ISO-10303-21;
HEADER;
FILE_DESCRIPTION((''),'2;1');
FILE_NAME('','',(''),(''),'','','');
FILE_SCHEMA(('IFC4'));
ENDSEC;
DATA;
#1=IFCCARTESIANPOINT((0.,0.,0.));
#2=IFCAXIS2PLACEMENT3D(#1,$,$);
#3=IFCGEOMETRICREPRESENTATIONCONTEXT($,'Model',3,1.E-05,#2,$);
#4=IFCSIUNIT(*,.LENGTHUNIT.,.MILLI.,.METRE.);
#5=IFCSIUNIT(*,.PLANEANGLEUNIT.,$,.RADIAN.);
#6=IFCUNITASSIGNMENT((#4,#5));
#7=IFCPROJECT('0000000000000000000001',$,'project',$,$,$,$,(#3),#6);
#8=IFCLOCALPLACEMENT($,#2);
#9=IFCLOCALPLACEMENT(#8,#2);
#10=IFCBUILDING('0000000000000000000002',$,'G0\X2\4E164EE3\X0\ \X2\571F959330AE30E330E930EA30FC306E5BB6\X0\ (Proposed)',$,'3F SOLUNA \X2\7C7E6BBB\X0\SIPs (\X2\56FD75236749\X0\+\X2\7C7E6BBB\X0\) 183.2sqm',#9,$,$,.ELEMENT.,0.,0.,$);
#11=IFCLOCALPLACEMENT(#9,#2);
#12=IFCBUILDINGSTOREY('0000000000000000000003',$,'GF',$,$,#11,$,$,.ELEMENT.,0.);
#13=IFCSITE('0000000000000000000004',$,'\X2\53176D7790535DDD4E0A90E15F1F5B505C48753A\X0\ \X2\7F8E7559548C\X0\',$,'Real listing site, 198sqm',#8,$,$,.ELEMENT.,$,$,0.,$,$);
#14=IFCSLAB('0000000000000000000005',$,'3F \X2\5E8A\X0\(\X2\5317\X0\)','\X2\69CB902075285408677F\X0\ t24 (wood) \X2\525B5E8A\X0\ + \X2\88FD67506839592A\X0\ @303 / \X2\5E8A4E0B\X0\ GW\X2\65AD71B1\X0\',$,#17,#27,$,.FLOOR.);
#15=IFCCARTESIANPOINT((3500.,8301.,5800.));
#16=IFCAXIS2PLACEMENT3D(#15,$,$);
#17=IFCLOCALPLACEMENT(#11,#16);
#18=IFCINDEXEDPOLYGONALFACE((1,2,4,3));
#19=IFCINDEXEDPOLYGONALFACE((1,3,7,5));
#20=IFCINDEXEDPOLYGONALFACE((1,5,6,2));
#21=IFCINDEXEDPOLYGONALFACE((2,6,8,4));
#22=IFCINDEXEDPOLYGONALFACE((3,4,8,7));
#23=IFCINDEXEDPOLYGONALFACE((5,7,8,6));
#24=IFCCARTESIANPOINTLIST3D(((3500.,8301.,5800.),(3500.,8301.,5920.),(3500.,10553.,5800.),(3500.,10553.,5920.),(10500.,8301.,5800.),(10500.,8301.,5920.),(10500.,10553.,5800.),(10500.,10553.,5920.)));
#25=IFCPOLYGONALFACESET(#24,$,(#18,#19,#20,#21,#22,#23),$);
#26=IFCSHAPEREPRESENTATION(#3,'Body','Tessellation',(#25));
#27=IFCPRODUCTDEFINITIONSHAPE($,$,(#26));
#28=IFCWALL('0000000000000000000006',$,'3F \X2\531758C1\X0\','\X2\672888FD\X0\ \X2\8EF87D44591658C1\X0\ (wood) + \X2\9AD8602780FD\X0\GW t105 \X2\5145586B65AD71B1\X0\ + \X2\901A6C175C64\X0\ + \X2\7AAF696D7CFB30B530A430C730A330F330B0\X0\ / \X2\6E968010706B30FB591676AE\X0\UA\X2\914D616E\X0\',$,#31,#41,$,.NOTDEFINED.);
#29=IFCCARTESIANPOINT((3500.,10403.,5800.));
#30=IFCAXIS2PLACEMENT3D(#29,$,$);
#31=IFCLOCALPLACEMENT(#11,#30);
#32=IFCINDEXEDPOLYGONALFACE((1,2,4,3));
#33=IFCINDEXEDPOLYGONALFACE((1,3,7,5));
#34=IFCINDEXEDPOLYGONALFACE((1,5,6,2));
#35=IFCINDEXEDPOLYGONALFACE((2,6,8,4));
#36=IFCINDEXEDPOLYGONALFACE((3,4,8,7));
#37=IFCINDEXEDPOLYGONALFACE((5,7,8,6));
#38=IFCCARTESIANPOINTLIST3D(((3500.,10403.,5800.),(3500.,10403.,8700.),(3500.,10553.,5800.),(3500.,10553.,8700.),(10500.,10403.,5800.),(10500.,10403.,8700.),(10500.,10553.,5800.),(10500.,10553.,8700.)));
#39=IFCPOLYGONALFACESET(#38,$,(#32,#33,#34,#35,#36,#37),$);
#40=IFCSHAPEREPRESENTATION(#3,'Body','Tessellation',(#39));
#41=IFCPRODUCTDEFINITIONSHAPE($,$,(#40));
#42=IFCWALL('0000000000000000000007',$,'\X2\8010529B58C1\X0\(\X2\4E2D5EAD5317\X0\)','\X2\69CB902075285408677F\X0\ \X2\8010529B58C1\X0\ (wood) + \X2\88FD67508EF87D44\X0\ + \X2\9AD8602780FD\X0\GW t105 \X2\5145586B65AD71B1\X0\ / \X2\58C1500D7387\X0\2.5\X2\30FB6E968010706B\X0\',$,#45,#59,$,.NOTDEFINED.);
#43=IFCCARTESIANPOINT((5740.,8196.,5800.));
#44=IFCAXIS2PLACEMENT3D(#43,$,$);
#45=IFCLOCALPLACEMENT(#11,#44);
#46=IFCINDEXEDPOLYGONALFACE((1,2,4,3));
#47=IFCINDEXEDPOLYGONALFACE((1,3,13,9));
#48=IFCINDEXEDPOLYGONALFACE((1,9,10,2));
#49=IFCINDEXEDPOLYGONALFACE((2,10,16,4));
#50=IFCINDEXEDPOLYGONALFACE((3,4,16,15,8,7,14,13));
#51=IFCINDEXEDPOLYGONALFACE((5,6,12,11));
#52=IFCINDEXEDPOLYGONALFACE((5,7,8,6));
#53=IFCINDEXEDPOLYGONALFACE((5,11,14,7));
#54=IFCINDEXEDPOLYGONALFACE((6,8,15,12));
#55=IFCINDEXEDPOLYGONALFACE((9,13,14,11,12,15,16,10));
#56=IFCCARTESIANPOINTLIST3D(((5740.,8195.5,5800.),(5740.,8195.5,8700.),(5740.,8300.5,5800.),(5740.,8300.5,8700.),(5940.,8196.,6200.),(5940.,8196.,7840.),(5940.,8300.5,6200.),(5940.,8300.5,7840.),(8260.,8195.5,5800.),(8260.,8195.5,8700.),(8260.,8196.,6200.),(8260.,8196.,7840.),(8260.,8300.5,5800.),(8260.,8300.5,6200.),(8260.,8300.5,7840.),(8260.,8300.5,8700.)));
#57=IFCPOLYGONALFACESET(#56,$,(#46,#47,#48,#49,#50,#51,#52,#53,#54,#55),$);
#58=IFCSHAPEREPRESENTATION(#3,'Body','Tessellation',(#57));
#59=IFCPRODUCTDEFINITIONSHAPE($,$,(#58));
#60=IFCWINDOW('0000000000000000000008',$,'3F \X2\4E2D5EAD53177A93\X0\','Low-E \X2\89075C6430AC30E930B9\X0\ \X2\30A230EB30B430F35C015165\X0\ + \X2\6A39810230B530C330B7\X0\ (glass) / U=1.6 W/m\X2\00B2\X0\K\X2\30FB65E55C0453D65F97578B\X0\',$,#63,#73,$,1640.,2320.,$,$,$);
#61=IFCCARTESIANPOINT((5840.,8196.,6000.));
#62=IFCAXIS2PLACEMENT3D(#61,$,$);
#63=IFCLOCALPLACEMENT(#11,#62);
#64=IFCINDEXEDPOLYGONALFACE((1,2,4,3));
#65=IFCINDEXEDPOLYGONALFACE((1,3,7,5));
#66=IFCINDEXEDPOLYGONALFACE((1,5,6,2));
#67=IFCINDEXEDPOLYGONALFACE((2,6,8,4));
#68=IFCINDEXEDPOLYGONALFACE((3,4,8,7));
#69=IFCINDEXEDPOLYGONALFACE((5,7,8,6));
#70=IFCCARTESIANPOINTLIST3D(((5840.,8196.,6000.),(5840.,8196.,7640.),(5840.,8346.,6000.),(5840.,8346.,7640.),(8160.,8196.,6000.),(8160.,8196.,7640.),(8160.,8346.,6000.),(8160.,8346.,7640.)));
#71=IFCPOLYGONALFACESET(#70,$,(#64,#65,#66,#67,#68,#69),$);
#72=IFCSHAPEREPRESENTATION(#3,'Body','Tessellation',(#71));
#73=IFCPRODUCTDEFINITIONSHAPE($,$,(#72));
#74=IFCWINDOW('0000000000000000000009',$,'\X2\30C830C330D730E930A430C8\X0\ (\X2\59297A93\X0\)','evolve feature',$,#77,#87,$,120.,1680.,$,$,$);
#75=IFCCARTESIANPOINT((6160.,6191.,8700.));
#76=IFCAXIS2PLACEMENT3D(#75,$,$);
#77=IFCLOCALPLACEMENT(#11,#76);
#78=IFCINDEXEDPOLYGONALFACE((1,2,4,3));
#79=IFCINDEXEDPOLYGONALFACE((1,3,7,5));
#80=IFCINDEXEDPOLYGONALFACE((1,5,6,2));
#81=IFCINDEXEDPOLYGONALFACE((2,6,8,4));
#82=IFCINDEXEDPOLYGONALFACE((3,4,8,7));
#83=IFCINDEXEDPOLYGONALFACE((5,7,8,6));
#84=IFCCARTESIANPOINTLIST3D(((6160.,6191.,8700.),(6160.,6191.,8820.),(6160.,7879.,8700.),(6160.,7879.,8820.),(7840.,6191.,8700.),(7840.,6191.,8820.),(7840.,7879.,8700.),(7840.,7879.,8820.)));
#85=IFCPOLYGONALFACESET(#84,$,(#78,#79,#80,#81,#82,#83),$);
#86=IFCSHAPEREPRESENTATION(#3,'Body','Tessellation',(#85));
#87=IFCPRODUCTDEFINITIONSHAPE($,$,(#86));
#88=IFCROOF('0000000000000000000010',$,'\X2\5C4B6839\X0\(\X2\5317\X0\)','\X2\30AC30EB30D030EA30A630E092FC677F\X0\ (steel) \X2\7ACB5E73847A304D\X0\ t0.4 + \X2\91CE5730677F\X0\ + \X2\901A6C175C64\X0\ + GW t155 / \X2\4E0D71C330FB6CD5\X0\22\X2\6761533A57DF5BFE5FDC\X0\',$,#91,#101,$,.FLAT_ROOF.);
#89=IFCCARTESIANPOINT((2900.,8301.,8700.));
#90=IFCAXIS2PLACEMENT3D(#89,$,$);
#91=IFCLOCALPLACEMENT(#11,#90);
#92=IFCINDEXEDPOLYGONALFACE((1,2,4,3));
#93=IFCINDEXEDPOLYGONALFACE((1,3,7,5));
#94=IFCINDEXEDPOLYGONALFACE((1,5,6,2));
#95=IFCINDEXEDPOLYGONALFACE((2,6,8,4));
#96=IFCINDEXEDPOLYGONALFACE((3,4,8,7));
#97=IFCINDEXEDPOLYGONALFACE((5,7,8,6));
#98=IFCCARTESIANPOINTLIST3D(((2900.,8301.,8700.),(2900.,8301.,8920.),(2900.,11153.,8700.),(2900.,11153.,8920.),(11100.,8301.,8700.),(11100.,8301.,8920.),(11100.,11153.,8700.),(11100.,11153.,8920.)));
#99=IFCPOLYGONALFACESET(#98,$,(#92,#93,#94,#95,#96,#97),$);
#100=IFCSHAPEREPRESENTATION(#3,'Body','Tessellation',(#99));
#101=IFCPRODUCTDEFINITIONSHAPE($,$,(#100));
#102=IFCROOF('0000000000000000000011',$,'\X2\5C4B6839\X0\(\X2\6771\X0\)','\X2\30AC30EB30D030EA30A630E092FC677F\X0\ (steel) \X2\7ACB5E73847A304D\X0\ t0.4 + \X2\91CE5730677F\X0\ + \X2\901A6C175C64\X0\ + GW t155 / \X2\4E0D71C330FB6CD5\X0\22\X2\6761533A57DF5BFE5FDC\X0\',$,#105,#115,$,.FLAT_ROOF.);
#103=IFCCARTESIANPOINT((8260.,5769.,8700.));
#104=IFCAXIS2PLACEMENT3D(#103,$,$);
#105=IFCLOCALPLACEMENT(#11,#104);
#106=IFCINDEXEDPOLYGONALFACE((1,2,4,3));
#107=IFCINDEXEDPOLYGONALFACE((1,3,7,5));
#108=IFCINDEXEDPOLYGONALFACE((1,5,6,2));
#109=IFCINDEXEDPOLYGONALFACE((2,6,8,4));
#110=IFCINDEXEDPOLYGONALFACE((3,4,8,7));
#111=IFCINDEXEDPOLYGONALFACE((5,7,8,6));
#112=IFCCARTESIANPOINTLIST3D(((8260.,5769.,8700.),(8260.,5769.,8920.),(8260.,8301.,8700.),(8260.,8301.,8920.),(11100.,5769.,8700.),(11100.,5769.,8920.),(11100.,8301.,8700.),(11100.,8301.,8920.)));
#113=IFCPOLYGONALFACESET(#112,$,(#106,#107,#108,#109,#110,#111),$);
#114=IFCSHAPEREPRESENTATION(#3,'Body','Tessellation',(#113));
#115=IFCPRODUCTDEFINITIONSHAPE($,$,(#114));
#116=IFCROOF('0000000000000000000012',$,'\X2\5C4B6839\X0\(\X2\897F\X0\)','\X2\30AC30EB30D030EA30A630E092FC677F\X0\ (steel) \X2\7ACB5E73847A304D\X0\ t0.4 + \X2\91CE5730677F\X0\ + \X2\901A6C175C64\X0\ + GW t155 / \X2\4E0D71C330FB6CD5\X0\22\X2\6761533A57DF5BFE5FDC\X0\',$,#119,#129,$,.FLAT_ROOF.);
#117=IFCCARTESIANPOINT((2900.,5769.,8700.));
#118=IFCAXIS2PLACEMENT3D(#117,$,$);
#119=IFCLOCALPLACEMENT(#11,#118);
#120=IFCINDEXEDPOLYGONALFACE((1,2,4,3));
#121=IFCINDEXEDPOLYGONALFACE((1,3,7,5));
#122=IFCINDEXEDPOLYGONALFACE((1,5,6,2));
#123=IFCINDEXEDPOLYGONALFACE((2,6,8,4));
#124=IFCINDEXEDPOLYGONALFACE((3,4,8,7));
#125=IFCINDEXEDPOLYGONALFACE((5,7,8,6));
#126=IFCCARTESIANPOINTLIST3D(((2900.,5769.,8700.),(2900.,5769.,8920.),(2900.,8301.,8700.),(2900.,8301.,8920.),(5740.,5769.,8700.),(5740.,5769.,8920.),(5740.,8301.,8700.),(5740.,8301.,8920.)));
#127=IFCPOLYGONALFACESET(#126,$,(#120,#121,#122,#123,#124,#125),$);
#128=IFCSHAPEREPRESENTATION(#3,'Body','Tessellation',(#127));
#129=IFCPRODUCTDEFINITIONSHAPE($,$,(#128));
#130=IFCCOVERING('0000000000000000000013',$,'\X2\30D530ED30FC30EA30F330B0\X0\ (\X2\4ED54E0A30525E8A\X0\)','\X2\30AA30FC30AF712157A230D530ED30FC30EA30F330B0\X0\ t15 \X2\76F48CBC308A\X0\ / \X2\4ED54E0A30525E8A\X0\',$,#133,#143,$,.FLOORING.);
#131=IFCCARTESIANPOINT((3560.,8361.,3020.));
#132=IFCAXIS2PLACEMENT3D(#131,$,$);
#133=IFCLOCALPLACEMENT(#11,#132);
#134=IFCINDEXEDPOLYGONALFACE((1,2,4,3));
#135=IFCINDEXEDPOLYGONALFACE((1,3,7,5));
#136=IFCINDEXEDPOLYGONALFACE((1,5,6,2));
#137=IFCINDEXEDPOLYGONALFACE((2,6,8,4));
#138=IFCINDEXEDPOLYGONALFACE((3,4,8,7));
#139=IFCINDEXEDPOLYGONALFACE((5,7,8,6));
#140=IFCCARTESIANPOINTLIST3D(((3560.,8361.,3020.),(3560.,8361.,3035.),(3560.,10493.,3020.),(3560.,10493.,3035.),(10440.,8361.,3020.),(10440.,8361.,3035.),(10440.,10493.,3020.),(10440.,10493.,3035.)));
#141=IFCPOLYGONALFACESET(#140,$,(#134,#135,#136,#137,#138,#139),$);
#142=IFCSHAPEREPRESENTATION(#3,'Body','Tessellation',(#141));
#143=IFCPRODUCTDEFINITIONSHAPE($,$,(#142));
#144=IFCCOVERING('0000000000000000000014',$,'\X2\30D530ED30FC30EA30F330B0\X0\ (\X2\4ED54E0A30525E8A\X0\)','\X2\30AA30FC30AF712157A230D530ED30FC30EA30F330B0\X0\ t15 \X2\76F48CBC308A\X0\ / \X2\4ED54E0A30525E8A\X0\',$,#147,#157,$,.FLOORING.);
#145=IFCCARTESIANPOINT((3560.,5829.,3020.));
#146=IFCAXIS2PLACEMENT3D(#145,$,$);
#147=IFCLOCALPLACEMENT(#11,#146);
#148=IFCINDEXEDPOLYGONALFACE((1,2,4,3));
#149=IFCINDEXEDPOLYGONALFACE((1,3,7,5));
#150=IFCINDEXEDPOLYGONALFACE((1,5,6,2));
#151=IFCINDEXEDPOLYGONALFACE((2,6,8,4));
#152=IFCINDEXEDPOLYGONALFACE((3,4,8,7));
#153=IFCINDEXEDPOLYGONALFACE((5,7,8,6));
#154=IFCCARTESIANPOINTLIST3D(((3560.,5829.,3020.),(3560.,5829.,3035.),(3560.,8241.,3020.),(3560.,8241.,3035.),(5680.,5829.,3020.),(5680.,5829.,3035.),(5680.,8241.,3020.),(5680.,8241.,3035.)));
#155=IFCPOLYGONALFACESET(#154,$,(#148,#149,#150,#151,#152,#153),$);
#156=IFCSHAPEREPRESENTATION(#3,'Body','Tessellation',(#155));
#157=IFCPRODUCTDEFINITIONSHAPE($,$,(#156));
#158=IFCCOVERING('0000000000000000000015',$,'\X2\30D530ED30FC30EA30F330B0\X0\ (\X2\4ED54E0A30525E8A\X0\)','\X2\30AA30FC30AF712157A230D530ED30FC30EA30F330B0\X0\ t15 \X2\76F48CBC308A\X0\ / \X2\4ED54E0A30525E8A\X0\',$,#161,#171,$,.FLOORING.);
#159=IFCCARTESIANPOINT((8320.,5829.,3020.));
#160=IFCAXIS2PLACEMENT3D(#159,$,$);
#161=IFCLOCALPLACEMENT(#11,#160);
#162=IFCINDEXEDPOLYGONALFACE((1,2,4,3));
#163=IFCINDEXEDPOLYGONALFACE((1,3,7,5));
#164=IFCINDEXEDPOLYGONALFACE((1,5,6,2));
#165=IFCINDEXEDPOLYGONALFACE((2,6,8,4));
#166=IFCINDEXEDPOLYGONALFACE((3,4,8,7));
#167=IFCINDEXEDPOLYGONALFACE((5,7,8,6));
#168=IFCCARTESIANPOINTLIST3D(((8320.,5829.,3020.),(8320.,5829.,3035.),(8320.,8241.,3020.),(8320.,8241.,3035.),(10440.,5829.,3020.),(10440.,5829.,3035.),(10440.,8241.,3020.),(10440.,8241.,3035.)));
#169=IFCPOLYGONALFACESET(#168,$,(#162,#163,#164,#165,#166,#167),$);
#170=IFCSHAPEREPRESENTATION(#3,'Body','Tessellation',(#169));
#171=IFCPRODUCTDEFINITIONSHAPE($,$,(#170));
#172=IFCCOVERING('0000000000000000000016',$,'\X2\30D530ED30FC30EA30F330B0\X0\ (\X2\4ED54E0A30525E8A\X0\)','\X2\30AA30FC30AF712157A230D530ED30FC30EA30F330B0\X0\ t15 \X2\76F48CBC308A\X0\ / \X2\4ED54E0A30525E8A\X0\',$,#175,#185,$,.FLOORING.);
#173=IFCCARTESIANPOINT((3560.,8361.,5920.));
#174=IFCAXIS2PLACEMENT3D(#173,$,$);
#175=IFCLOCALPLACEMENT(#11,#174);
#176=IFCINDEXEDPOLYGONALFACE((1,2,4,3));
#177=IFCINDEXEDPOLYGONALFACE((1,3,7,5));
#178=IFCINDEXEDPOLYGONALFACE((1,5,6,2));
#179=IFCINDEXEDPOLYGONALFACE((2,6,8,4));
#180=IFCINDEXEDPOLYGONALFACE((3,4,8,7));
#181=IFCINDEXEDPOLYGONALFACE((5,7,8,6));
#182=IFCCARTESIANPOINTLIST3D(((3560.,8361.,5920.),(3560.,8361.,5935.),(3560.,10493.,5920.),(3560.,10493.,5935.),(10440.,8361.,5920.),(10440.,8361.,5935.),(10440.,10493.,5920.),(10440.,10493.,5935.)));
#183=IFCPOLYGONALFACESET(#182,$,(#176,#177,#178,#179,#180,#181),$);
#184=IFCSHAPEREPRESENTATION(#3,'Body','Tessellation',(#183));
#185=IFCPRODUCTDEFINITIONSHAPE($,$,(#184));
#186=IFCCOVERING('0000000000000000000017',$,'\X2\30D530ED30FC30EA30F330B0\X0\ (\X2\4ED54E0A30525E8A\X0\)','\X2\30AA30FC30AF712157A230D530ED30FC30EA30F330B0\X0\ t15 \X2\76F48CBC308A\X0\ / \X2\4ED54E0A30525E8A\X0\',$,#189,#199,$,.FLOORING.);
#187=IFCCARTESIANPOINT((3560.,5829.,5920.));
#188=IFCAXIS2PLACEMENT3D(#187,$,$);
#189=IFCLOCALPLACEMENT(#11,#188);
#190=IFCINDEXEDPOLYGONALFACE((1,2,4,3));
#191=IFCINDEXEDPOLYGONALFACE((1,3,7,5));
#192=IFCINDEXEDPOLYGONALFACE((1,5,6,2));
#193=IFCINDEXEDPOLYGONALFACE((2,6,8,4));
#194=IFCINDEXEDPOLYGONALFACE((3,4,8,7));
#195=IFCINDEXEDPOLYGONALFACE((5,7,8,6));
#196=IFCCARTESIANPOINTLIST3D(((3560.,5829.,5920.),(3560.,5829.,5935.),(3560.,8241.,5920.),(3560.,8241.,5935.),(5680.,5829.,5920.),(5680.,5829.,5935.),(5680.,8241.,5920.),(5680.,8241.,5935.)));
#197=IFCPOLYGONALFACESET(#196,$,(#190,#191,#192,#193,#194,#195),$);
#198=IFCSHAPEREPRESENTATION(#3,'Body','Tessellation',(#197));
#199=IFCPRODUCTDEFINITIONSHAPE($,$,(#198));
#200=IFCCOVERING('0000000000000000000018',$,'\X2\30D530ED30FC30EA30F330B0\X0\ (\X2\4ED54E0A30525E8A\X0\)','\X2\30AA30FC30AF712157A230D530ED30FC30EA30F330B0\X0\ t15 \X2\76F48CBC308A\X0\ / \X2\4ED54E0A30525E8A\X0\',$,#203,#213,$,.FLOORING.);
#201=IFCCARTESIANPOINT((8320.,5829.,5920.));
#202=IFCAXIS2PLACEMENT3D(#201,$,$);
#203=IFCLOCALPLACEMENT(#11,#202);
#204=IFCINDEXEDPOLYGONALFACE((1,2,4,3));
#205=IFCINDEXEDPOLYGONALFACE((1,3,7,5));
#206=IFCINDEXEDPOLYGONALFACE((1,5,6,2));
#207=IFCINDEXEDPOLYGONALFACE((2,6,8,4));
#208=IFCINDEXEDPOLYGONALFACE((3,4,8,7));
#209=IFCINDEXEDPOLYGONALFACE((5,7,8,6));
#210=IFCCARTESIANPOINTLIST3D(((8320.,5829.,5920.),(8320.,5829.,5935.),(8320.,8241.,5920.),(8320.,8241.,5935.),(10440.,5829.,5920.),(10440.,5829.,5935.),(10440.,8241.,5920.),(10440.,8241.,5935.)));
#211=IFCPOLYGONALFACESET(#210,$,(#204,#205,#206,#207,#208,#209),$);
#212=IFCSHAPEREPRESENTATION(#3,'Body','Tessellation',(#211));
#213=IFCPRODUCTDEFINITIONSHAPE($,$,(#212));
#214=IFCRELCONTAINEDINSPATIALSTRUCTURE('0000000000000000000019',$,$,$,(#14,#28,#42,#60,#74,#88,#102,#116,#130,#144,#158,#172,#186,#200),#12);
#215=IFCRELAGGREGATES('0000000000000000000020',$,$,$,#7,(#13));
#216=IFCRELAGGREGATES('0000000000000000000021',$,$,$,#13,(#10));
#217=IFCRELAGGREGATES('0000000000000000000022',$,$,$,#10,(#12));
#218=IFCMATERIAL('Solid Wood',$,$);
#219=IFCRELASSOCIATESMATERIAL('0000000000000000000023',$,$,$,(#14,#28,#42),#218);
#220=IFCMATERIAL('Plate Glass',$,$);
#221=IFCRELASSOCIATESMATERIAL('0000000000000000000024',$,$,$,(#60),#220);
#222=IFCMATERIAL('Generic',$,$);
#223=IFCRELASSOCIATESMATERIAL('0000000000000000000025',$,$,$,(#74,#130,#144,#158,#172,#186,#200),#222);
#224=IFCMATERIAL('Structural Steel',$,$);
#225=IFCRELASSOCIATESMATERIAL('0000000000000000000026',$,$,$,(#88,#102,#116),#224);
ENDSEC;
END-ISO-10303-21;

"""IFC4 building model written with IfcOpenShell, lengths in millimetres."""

from ifc_helpers import new_model, si_unit, frame, frame_2d, origin, place, context, project, spatial, rectangle, extrude, material, element, fill, save


model = new_model("IFC4")

# Units and contexts
model_context = context("Model", 3, precision=1e-05, world=origin())
ifc_project = project(units=[si_unit("LENGTHUNIT", "METRE", prefix="MILLI"), si_unit("PLANEANGLEUNIT", "RADIAN")], contexts=[model_context])

# Site, building, storey
site_placement = place(None, origin())
site = spatial("IfcSite", under=ifc_project, at=site_placement, Name="北海道川上郡弟子屈町 美留和", ObjectType="Real listing site, 198sqm", CompositionType="ELEMENT", RefElevation=0.0)
building_placement = place(site_placement, origin())
building = spatial("IfcBuilding", under=site, at=building_placement, Name="G0世代 土間ギャラリーの家 (Proposed)", ObjectType="3F SOLUNA 籾殻SIPs (国産杉+籾殻) 183.2sqm", CompositionType="ELEMENT", ElevationOfRefHeight=0.0, ElevationOfTerrain=0.0)
storey_placement = place(building_placement, origin())
storey = spatial("IfcBuildingStorey", under=building, at=storey_placement, Name="GF", CompositionType="ELEMENT", Elevation=0.0)

# Slab
ifc_material_1 = material(Name="Solid Wood")
slab_placement = place(storey_placement, frame((3500.0, 8301.0, 5800.0)))
element("IfcSlab", 1, at=slab_placement, inside=storey, material=ifc_material_1, Name="3F 床(北)", Description="構造用合板 t24 (wood) 剛床 + 製材根太 @303 / 床下 GW断熱", PredefinedType="FLOOR", context=model_context, shape_type="SweptSolid", body=[
    extrude(rectangle(XDim=7000.0, YDim=2252.0, at=frame_2d((3500.0, 1126.0))), frame((3500.0, 8301.0, 5800.0)), (0.0, 0.0, 1.0), 120.0),
])

# Wall
wall_1_placement = place(storey_placement, frame((3500.0, 10403.0, 5800.0)))
element("IfcWall", 2, at=wall_1_placement, inside=storey, material=ifc_material_1, Name="3F 北壁", Description="木製 軸組外壁 (wood) + 高性能GW t105 充填断熱 + 通気層 + 窯業系サイディング / 準耐火・外皮UA配慮", PredefinedType="NOTDEFINED", context=model_context, shape_type="SweptSolid", body=[
    extrude(rectangle(XDim=7000.0, YDim=150.0, at=frame_2d((3500.0, 75.0))), frame((3500.0, 10403.0, 5800.0)), (0.0, 0.0, 1.0), 2900.0),
])

# Wall, opening, window
wall_2_placement = place(storey_placement, frame((5740.0, 8196.0, 5800.0)))
wall_2 = element("IfcWall", 3, at=wall_2_placement, inside=storey, material=ifc_material_1, Name="耐力壁(中庭北)", Description="構造用合板 耐力壁 (wood) + 製材軸組 + 高性能GW t105 充填断熱 / 壁倍率2.5・準耐火", PredefinedType="NOTDEFINED", context=model_context, shape_type="SweptSolid", body=[
    extrude(rectangle(XDim=2520.0, YDim=105.0, at=frame_2d((1260.0, 52.0))), frame((5740.0, 8196.0, 5800.0)), (0.0, 0.0, 1.0), 2900.0),
])
opening_placement = place(storey_placement, frame((5840.0, 8196.0, 6000.0)))
opening = element("IfcOpeningElement", 4, at=opening_placement, cuts=wall_2, PredefinedType="NOTDEFINED", context=model_context, shape_type="SweptSolid", body=[
    extrude(rectangle(XDim=2320.0, YDim=150.0, at=frame_2d((1160.0, 75.0))), frame((5840.0, 8196.0, 6000.0)), (0.0, 0.0, 1.0), 1640.0),
])
ifc_material_2 = material(Name="Plate Glass")
window_1_placement = place(storey_placement, frame((5840.0, 8196.0, 6000.0)))
window_1 = element("IfcWindow", 5, at=window_1_placement, inside=storey, material=ifc_material_2, Name="3F 中庭北窓", Description="Low-E 複層ガラス アルゴン封入 + 樹脂サッシ (glass) / U=1.6 W/m²K・日射取得型", OverallHeight=1640.0, OverallWidth=2320.0, context=model_context, shape_type="SweptSolid", body=[
    extrude(rectangle(XDim=2320.0, YDim=150.0, at=frame_2d((1160.0, 75.0))), frame((5840.0, 8196.0, 6000.0)), (0.0, 0.0, 1.0), 1640.0),
])
fill(opening, window_1)

# Window
ifc_material_3 = material(Name="Generic")
window_2_placement = place(storey_placement, frame((6160.0, 6191.0, 8700.0)))
element("IfcWindow", 6, at=window_2_placement, inside=storey, material=ifc_material_3, Name="トップライト (天窓)", Description="evolve feature", OverallHeight=120.0, OverallWidth=1680.0, context=model_context, shape_type="SweptSolid", body=[
    extrude(rectangle(XDim=1680.0, YDim=1688.0, at=frame_2d((840.0, 844.0))), frame((6160.0, 6191.0, 8700.0)), (0.0, 0.0, 1.0), 120.0),
])

# Roofs
ifc_material_4 = material(Name="Structural Steel")
roof_1_placement = place(storey_placement, frame((2900.0, 8301.0, 8700.0)))
element("IfcRoof", 7, at=roof_1_placement, inside=storey, material=ifc_material_4, Name="屋根(北)", Description="ガルバリウム鋼板 (steel) 立平葺き t0.4 + 野地板 + 通気層 + GW t155 / 不燃・法22条区域対応", PredefinedType="FLAT_ROOF", context=model_context, shape_type="SweptSolid", body=[
    extrude(rectangle(XDim=8200.0, YDim=2852.0, at=frame_2d((4100.0, 1426.0))), frame((2900.0, 8301.0, 8700.0)), (0.0, 0.0, 1.0), 220.0),
])
roof_2_placement = place(storey_placement, frame((8260.0, 5769.0, 8700.0)))
element("IfcRoof", 8, at=roof_2_placement, inside=storey, material=ifc_material_4, Name="屋根(東)", Description="ガルバリウム鋼板 (steel) 立平葺き t0.4 + 野地板 + 通気層 + GW t155 / 不燃・法22条区域対応", PredefinedType="FLAT_ROOF", context=model_context, shape_type="SweptSolid", body=[
    extrude(rectangle(XDim=2840.0, YDim=2532.0, at=frame_2d((1420.0, 1266.0))), frame((8260.0, 5769.0, 8700.0)), (0.0, 0.0, 1.0), 220.0),
])
roof_3_placement = place(storey_placement, frame((2900.0, 5769.0, 8700.0)))
element("IfcRoof", 9, at=roof_3_placement, inside=storey, material=ifc_material_4, Name="屋根(西)", Description="ガルバリウム鋼板 (steel) 立平葺き t0.4 + 野地板 + 通気層 + GW t155 / 不燃・法22条区域対応", PredefinedType="FLAT_ROOF", context=model_context, shape_type="SweptSolid", body=[
    extrude(rectangle(XDim=2840.0, YDim=2532.0, at=frame_2d((1420.0, 1266.0))), frame((2900.0, 5769.0, 8700.0)), (0.0, 0.0, 1.0), 220.0),
])

# Coverings
covering_1_placement = place(storey_placement, frame((3560.0, 8361.0, 3020.0)))
element("IfcCovering", 10, at=covering_1_placement, inside=storey, material=ifc_material_3, Name="フローリング (仕上げ床)", Description="オーク無垢フローリング t15 直貼り / 仕上げ床", PredefinedType="FLOORING", context=model_context, shape_type="SweptSolid", body=[
    extrude(rectangle(XDim=6880.0, YDim=2132.0, at=frame_2d((3440.0, 1066.0))), frame((3560.0, 8361.0, 3020.0)), (0.0, 0.0, 1.0), 15.0),
])
covering_2_placement = place(storey_placement, frame((3560.0, 5829.0, 3020.0)))
element("IfcCovering", 11, at=covering_2_placement, inside=storey, material=ifc_material_3, Name="フローリング (仕上げ床)", Description="オーク無垢フローリング t15 直貼り / 仕上げ床", PredefinedType="FLOORING", context=model_context, shape_type="SweptSolid", body=[
    extrude(rectangle(XDim=2120.0, YDim=2412.0, at=frame_2d((1060.0, 1206.0))), frame((3560.0, 5829.0, 3020.0)), (0.0, 0.0, 1.0), 15.0),
])
covering_3_placement = place(storey_placement, frame((8320.0, 5829.0, 3020.0)))
element("IfcCovering", 12, at=covering_3_placement, inside=storey, material=ifc_material_3, Name="フローリング (仕上げ床)", Description="オーク無垢フローリング t15 直貼り / 仕上げ床", PredefinedType="FLOORING", context=model_context, shape_type="SweptSolid", body=[
    extrude(rectangle(XDim=2120.0, YDim=2412.0, at=frame_2d((1060.0, 1206.0))), frame((8320.0, 5829.0, 3020.0)), (0.0, 0.0, 1.0), 15.0),
])
covering_4_placement = place(storey_placement, frame((3560.0, 8361.0, 5920.0)))
element("IfcCovering", 13, at=covering_4_placement, inside=storey, material=ifc_material_3, Name="フローリング (仕上げ床)", Description="オーク無垢フローリング t15 直貼り / 仕上げ床", PredefinedType="FLOORING", context=model_context, shape_type="SweptSolid", body=[
    extrude(rectangle(XDim=6880.0, YDim=2132.0, at=frame_2d((3440.0, 1066.0))), frame((3560.0, 8361.0, 5920.0)), (0.0, 0.0, 1.0), 15.0),
])
covering_5_placement = place(storey_placement, frame((3560.0, 5829.0, 5920.0)))
element("IfcCovering", 14, at=covering_5_placement, inside=storey, material=ifc_material_3, Name="フローリング (仕上げ床)", Description="オーク無垢フローリング t15 直貼り / 仕上げ床", PredefinedType="FLOORING", context=model_context, shape_type="SweptSolid", body=[
    extrude(rectangle(XDim=2120.0, YDim=2412.0, at=frame_2d((1060.0, 1206.0))), frame((3560.0, 5829.0, 5920.0)), (0.0, 0.0, 1.0), 15.0),
])
covering_6_placement = place(storey_placement, frame((8320.0, 5829.0, 5920.0)))
element("IfcCovering", 15, at=covering_6_placement, inside=storey, material=ifc_material_3, Name="フローリング (仕上げ床)", Description="オーク無垢フローリング t15 直貼り / 仕上げ床", PredefinedType="FLOORING", context=model_context, shape_type="SweptSolid", body=[
    extrude(rectangle(XDim=2120.0, YDim=2412.0, at=frame_2d((1060.0, 1206.0))), frame((8320.0, 5829.0, 5920.0)), (0.0, 0.0, 1.0), 15.0),
])

save(model, "model.ifc")
